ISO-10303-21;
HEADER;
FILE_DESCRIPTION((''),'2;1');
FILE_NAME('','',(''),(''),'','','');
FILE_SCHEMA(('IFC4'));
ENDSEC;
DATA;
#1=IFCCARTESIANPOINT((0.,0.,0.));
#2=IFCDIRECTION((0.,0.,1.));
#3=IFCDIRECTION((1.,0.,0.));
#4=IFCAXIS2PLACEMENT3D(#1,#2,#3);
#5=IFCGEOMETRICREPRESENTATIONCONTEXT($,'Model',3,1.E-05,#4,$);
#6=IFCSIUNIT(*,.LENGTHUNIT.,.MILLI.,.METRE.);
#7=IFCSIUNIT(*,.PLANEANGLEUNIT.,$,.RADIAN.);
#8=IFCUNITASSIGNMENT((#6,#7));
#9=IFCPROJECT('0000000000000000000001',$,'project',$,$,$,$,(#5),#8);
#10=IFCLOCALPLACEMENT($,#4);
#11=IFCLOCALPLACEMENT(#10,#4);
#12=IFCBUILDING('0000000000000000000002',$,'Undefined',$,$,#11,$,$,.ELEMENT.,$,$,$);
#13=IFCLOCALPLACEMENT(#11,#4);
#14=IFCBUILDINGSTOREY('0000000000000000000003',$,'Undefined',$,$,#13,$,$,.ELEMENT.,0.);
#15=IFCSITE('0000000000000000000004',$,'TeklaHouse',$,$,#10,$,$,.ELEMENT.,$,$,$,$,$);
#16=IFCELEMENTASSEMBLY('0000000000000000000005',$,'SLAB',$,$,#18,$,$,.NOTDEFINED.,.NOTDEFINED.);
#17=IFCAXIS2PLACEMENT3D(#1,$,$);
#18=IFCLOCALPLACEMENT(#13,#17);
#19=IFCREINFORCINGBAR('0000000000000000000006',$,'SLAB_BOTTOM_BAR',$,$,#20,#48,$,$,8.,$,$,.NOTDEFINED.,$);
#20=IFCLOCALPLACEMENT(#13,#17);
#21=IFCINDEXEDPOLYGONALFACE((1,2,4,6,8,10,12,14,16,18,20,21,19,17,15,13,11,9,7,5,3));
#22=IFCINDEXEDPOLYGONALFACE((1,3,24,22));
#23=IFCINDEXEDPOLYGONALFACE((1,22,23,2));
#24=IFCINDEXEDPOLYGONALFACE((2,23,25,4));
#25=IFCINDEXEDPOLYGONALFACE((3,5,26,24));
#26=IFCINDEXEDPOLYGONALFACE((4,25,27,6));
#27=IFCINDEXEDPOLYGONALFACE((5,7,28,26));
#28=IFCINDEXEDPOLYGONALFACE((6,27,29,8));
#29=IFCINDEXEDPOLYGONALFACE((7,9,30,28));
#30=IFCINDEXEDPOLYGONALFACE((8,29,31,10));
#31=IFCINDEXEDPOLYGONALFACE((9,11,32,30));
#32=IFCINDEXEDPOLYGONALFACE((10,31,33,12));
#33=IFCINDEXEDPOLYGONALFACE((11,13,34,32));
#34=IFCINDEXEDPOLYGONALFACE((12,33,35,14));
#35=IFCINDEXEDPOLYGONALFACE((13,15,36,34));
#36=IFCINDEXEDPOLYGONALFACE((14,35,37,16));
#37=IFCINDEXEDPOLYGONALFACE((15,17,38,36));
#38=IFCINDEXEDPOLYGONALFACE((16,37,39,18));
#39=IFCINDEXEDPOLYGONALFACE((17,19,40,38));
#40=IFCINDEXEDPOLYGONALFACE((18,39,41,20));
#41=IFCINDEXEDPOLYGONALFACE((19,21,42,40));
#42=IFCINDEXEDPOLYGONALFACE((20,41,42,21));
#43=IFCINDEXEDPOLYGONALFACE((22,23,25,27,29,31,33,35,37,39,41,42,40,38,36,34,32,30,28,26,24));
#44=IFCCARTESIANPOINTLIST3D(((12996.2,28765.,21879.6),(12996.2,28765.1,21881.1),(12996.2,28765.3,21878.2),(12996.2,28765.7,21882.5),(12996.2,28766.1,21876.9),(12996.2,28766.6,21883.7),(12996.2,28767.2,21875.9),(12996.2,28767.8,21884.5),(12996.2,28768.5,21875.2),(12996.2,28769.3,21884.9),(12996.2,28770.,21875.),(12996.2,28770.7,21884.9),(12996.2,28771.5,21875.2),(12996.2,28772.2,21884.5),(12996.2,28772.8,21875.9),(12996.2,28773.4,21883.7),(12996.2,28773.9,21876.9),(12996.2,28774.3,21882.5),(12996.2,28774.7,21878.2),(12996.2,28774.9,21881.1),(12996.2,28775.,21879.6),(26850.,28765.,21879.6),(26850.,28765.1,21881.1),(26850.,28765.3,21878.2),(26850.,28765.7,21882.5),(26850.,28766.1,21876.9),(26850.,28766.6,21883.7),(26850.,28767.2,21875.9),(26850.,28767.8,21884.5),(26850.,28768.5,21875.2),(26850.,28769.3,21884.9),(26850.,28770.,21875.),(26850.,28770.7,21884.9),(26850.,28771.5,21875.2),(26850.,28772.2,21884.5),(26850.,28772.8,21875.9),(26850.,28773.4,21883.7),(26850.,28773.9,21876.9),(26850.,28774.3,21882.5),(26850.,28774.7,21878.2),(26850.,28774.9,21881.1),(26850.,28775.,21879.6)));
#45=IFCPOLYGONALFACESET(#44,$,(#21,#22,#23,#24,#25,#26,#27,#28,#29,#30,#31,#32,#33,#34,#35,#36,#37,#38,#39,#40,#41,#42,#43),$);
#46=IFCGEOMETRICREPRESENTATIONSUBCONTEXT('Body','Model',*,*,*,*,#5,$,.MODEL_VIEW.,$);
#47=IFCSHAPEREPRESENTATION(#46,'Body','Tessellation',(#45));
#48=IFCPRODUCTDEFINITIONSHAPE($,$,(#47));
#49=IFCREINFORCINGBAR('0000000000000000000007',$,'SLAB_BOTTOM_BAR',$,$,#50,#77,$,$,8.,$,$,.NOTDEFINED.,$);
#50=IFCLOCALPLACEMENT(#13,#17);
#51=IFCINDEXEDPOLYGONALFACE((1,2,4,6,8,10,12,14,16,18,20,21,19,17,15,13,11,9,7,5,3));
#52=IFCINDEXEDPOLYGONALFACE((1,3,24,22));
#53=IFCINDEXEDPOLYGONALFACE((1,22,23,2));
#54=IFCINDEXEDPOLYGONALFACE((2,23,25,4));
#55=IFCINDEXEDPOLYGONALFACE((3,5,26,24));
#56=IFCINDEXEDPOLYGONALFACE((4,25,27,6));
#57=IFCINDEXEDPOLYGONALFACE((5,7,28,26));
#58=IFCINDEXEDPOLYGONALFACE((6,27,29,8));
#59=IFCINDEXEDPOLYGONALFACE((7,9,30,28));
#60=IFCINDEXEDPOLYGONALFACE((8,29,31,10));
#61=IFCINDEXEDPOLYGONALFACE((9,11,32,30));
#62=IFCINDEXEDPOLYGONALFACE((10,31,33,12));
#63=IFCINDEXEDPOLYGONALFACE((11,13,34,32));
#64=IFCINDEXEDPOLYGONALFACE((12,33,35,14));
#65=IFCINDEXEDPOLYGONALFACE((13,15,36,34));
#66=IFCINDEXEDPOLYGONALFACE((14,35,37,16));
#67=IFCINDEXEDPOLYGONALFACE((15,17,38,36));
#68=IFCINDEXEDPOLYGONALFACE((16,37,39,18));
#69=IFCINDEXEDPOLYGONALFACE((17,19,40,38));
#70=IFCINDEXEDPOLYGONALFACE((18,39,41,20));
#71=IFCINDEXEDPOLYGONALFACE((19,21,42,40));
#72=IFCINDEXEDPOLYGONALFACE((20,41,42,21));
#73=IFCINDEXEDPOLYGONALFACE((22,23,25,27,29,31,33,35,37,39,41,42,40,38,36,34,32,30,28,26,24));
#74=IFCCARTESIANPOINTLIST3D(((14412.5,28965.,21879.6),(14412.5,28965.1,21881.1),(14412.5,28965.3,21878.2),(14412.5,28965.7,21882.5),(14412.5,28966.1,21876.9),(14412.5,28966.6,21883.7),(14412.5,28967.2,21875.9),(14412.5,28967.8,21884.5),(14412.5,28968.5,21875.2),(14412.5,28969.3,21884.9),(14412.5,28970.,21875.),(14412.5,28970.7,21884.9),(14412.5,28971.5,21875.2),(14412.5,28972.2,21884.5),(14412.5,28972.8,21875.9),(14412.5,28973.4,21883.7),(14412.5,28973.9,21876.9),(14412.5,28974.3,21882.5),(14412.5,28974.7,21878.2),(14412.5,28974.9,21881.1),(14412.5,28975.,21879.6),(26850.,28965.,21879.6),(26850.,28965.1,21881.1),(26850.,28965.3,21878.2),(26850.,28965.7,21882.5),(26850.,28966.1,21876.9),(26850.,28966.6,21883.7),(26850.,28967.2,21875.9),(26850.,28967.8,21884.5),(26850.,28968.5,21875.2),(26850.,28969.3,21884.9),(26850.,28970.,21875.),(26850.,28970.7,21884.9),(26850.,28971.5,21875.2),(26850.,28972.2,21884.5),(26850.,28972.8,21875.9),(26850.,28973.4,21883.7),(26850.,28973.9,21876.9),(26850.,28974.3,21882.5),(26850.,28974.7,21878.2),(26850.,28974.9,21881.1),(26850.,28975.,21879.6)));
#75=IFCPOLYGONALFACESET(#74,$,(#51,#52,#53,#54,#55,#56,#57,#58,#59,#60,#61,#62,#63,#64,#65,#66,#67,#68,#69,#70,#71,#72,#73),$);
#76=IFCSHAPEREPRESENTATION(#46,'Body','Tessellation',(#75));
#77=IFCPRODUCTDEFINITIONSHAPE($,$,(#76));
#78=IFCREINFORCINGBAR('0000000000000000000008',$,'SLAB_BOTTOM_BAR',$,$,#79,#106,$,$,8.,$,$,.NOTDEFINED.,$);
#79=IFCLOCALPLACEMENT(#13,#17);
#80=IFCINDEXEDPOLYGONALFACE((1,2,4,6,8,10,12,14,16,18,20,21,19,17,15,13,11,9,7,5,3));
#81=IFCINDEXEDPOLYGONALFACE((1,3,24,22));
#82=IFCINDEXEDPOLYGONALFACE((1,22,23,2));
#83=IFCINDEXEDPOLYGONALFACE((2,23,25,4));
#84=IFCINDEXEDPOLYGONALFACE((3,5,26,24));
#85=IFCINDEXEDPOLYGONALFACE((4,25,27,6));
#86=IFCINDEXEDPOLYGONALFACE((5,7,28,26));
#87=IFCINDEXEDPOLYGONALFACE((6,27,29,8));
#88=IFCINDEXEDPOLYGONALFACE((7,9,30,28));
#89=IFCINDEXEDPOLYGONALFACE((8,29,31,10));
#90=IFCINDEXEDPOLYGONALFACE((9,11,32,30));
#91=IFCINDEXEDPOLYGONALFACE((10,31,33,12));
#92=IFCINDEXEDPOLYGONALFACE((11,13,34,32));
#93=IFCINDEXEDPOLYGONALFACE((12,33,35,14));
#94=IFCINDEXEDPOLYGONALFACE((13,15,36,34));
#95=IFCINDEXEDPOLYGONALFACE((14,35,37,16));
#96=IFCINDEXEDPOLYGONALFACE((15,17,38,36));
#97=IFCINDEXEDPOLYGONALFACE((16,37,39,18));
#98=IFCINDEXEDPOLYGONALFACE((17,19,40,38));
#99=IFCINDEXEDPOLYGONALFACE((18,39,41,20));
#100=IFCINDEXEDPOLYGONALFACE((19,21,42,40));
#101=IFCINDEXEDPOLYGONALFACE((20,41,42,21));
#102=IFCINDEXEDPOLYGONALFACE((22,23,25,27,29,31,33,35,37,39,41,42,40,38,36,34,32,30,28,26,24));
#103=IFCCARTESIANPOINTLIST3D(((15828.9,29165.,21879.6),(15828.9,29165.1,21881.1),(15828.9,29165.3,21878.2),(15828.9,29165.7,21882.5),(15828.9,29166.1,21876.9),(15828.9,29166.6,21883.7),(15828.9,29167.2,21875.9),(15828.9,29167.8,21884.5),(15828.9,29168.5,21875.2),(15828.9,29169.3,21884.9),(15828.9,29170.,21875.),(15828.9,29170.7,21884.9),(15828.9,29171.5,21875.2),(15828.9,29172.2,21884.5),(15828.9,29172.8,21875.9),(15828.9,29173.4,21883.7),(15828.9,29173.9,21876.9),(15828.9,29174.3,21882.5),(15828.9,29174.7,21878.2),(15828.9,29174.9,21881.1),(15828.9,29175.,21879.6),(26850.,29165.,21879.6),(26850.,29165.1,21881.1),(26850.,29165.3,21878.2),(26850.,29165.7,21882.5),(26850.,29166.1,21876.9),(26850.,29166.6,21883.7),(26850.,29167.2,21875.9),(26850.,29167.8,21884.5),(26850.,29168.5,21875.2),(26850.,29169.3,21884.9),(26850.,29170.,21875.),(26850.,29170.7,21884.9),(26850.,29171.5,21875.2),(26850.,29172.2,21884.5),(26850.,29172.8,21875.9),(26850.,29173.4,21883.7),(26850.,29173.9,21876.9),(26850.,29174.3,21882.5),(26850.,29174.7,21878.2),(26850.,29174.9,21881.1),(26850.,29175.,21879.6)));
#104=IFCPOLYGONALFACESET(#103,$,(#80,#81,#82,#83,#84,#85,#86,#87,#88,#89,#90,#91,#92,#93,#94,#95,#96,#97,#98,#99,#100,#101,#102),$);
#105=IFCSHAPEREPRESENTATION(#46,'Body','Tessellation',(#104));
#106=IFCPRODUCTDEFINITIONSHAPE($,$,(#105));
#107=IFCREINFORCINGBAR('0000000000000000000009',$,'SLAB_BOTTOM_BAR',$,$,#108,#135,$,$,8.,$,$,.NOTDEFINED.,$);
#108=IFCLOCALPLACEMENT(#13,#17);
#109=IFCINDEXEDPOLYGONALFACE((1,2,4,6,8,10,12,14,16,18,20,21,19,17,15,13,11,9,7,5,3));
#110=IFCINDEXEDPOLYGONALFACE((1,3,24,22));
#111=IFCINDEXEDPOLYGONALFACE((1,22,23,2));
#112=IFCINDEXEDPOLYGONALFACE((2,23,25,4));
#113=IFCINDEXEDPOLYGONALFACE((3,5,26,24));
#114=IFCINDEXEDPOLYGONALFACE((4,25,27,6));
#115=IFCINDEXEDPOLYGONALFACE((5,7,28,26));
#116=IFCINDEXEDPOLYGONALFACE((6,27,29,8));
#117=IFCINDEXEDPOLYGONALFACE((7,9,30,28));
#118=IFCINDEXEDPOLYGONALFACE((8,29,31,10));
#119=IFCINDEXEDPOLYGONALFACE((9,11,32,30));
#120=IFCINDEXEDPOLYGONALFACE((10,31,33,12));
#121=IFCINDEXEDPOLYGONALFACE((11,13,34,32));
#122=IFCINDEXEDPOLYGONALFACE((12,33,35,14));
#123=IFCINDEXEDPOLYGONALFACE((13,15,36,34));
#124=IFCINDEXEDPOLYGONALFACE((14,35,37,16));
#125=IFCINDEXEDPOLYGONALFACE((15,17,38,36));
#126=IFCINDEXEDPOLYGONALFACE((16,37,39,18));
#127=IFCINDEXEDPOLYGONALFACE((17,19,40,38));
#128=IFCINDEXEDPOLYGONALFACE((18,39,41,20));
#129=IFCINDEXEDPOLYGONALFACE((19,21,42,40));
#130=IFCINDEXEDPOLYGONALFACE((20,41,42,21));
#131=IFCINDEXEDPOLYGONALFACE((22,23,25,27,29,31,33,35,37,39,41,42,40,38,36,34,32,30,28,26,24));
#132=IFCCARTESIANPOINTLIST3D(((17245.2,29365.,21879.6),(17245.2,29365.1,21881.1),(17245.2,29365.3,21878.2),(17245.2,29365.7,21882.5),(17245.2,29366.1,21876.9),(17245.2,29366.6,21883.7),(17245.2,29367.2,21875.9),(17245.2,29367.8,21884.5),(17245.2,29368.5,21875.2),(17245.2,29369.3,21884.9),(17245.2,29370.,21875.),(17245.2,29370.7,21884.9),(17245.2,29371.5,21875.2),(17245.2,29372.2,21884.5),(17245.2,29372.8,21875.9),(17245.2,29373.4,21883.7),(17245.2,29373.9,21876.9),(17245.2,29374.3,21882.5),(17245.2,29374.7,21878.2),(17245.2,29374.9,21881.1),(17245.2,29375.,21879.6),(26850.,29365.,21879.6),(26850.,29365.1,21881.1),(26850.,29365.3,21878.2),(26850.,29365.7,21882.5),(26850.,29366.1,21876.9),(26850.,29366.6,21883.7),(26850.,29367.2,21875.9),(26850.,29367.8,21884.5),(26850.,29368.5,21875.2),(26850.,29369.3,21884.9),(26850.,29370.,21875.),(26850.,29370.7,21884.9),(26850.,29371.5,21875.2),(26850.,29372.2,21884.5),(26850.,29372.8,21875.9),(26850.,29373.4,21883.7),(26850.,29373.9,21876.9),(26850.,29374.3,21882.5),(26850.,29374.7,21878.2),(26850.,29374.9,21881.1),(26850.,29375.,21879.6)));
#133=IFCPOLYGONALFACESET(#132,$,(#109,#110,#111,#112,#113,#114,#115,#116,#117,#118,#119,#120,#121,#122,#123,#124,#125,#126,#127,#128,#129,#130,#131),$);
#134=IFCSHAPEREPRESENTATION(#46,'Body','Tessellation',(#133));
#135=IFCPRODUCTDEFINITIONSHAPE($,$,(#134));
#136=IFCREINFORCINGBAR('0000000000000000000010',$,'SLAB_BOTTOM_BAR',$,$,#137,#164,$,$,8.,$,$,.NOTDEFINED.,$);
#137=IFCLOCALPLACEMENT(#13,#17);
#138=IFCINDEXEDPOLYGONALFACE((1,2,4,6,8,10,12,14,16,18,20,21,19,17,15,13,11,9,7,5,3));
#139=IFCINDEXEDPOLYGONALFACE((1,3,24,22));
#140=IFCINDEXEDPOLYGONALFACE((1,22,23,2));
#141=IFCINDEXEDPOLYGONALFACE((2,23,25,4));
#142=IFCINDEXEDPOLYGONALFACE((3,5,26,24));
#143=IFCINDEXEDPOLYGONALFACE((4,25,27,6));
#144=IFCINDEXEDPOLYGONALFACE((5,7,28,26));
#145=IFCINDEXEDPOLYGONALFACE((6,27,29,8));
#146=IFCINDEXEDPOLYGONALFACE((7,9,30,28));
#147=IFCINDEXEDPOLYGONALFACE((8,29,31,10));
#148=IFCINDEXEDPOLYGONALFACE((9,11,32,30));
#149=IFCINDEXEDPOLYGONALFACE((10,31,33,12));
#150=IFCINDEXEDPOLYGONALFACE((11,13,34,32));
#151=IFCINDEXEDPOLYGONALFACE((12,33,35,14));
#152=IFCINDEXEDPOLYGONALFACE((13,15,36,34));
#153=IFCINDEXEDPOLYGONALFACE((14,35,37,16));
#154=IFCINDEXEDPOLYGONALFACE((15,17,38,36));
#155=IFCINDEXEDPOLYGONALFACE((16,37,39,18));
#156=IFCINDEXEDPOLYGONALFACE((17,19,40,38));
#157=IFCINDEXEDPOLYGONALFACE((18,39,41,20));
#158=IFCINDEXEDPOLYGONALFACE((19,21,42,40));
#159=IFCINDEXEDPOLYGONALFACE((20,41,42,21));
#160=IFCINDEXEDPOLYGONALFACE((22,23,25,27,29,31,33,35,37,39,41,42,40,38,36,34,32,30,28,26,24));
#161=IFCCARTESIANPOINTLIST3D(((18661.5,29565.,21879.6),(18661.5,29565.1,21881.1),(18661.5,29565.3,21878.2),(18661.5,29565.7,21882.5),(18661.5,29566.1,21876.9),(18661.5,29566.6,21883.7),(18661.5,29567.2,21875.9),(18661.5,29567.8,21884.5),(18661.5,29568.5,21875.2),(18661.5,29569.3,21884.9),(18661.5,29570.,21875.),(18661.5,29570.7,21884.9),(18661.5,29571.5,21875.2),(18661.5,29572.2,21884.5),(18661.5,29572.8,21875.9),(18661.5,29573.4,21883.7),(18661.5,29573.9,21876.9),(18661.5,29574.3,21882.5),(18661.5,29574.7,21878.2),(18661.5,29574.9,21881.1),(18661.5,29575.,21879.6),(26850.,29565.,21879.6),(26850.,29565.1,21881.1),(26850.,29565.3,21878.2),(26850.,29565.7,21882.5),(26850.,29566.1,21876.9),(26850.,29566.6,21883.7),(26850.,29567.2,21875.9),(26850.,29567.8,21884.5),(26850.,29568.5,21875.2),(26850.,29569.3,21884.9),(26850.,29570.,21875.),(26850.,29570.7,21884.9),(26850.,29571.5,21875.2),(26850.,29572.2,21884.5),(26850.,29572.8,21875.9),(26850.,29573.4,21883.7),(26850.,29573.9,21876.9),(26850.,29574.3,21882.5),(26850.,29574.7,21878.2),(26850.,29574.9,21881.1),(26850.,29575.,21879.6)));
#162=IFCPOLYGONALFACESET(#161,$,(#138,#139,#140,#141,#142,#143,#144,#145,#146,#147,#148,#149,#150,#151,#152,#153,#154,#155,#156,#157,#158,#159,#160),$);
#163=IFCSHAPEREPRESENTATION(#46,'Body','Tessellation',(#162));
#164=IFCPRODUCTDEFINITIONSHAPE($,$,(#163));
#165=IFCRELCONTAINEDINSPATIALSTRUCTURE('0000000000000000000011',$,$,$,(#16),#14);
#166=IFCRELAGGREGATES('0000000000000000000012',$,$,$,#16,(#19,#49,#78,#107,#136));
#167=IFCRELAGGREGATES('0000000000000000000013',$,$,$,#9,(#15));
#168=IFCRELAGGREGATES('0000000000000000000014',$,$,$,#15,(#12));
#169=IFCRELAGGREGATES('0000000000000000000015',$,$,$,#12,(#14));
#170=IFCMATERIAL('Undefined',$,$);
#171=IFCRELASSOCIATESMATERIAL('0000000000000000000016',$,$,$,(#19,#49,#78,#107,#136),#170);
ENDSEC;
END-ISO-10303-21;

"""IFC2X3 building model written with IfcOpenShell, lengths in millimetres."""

from ifc_helpers import new_model, entity, si_unit, frame, origin_with_axes, place, context, subcontext, project, spatial, source, transform, mapped, material, element, aggregate, save


model = new_model("IFC2X3")

# Units and contexts
model_context = context("Model", 3, precision=1e-05, world=origin_with_axes())
body_context = subcontext(model_context, "Body", "Model", "MODEL_VIEW")
ifc_project = project(units=[si_unit("LENGTHUNIT", "METRE", prefix="MILLI"), si_unit("PLANEANGLEUNIT", "RADIAN")], contexts=[model_context])

# Site, building, storey
site_placement = place(None, origin_with_axes())
site = spatial("IfcSite", under=ifc_project, at=site_placement, Name="TeklaHouse", CompositionType="ELEMENT")
building_placement = place(site_placement, origin_with_axes())
building = spatial("IfcBuilding", under=site, at=building_placement, Name="Undefined", CompositionType="ELEMENT")
storey_placement = place(building_placement, origin_with_axes())
storey = spatial("IfcBuildingStorey", under=building, at=storey_placement, Name="Undefined", CompositionType="ELEMENT", Elevation=0.0)

# Element assembly, reinforcing bars
assembly_1_placement = place(storey_placement, origin_with_axes())
assembly_1 = element("IfcElementAssembly", 1, at=assembly_1_placement, inside=storey, Name="SLAB", AssemblyPlace="NOTDEFINED", PredefinedType="NOTDEFINED")
ifc_material_1 = material(Name="Undefined")
shared_shape_1 = source(origin_with_axes(), body_context, "Body", "AdvancedSweptSolid", [
    entity("IfcSweptDiskSolid", entity("IfcTrimmedCurve", entity("IfcLine", entity("IfcCartesianPoint", [0.0, 0.0, 0.0]), entity("IfcVector", entity("IfcDirection", [1.0, 0.0, 0.0]), 1.0)), [entity("IfcParameterValue", 0.0)], [entity("IfcParameterValue", 13853.787873)], True, "PARAMETER"), 5.0, None, 0.0, 13853.8),
])
reinforcing_bar_1_placement = place(assembly_1_placement, frame((26850.0, 28770.0, 21880.0), z_axis=(0.0, 0.0, -1.0), x_axis=(-1.0, 0.0, 0.0)))
reinforcing_bar_1 = element("IfcReinforcingBar", 2, at=reinforcing_bar_1_placement, material=ifc_material_1, Name="SLAB_BOTTOM_BAR", BarRole="NOTDEFINED", NominalDiameter=8.0, context=body_context, shape_type="MappedRepresentation", body=[
    mapped(shared_shape_1, transform((0.0, 0.0, 0.0))),
])
shared_shape_2 = source(origin_with_axes(), body_context, "Body", "AdvancedSweptSolid", [
    entity("IfcSweptDiskSolid", entity("IfcTrimmedCurve", entity("IfcLine", entity("IfcCartesianPoint", [0.0, 0.0, 0.0]), entity("IfcVector", entity("IfcDirection", [1.0, 0.0, 0.0]), 1.0)), [entity("IfcParameterValue", 0.0)], [entity("IfcParameterValue", 12437.463137)], True, "PARAMETER"), 5.0, None, 0.0, 12437.5),
])
reinforcing_bar_2_placement = place(assembly_1_placement, frame((26850.0, 28970.0, 21880.0), z_axis=(0.0, 0.0, -1.0), x_axis=(-1.0, 0.0, 0.0)))
reinforcing_bar_2 = element("IfcReinforcingBar", 3, at=reinforcing_bar_2_placement, material=ifc_material_1, Name="SLAB_BOTTOM_BAR", BarRole="NOTDEFINED", NominalDiameter=8.0, context=body_context, shape_type="MappedRepresentation", body=[
    mapped(shared_shape_2, transform((0.0, 0.0, 0.0))),
])
shared_shape_3 = source(origin_with_axes(), body_context, "Body", "AdvancedSweptSolid", [
    entity("IfcSweptDiskSolid", entity("IfcTrimmedCurve", entity("IfcLine", entity("IfcCartesianPoint", [0.0, 0.0, 0.0]), entity("IfcVector", entity("IfcDirection", [1.0, 0.0, 0.0]), 1.0)), [entity("IfcParameterValue", 0.0)], [entity("IfcParameterValue", 11021.1384)], True, "PARAMETER"), 5.0, None, 0.0, 11021.1),
])
reinforcing_bar_3_placement = place(assembly_1_placement, frame((26850.0, 29170.0, 21880.0), z_axis=(0.0, 0.0, -1.0), x_axis=(-1.0, 0.0, 0.0)))
reinforcing_bar_3 = element("IfcReinforcingBar", 4, at=reinforcing_bar_3_placement, material=ifc_material_1, Name="SLAB_BOTTOM_BAR", BarRole="NOTDEFINED", NominalDiameter=8.0, context=body_context, shape_type="MappedRepresentation", body=[
    mapped(shared_shape_3, transform((0.0, 0.0, 0.0))),
])
shared_shape_4 = source(origin_with_axes(), body_context, "Body", "AdvancedSweptSolid", [
    entity("IfcSweptDiskSolid", entity("IfcTrimmedCurve", entity("IfcLine", entity("IfcCartesianPoint", [0.0, 0.0, 0.0]), entity("IfcVector", entity("IfcDirection", [1.0, 0.0, 0.0]), 1.0)), [entity("IfcParameterValue", 0.0)], [entity("IfcParameterValue", 9604.813664)], True, "PARAMETER"), 5.0, None, 0.0, 9604.8),
])
reinforcing_bar_4_placement = place(assembly_1_placement, frame((26850.0, 29370.0, 21880.0), z_axis=(0.0, 0.0, -1.0), x_axis=(-1.0, 0.0, 0.0)))
reinforcing_bar_4 = element("IfcReinforcingBar", 5, at=reinforcing_bar_4_placement, material=ifc_material_1, Name="SLAB_BOTTOM_BAR", BarRole="NOTDEFINED", NominalDiameter=8.0, context=body_context, shape_type="MappedRepresentation", body=[
    mapped(shared_shape_4, transform((0.0, 0.0, 0.0))),
])
shared_shape_5 = source(origin_with_axes(), body_context, "Body", "AdvancedSweptSolid", [
    entity("IfcSweptDiskSolid", entity("IfcTrimmedCurve", entity("IfcLine", entity("IfcCartesianPoint", [0.0, 0.0, 0.0]), entity("IfcVector", entity("IfcDirection", [1.0, 0.0, 0.0]), 1.0)), [entity("IfcParameterValue", 0.0)], [entity("IfcParameterValue", 8188.488928)], True, "PARAMETER"), 5.0, None, 0.0, 8188.5),
])
reinforcing_bar_5_placement = place(assembly_1_placement, frame((26850.0, 29570.0, 21880.0), z_axis=(0.0, 0.0, -1.0), x_axis=(-1.0, 0.0, 0.0)))
reinforcing_bar_5 = element("IfcReinforcingBar", 6, at=reinforcing_bar_5_placement, material=ifc_material_1, Name="SLAB_BOTTOM_BAR", BarRole="NOTDEFINED", NominalDiameter=8.0, context=body_context, shape_type="MappedRepresentation", body=[
    mapped(shared_shape_5, transform((0.0, 0.0, 0.0))),
])
aggregate(assembly_1, [reinforcing_bar_1, reinforcing_bar_2, reinforcing_bar_3, reinforcing_bar_4, reinforcing_bar_5])

save(model, "model.ifc")
